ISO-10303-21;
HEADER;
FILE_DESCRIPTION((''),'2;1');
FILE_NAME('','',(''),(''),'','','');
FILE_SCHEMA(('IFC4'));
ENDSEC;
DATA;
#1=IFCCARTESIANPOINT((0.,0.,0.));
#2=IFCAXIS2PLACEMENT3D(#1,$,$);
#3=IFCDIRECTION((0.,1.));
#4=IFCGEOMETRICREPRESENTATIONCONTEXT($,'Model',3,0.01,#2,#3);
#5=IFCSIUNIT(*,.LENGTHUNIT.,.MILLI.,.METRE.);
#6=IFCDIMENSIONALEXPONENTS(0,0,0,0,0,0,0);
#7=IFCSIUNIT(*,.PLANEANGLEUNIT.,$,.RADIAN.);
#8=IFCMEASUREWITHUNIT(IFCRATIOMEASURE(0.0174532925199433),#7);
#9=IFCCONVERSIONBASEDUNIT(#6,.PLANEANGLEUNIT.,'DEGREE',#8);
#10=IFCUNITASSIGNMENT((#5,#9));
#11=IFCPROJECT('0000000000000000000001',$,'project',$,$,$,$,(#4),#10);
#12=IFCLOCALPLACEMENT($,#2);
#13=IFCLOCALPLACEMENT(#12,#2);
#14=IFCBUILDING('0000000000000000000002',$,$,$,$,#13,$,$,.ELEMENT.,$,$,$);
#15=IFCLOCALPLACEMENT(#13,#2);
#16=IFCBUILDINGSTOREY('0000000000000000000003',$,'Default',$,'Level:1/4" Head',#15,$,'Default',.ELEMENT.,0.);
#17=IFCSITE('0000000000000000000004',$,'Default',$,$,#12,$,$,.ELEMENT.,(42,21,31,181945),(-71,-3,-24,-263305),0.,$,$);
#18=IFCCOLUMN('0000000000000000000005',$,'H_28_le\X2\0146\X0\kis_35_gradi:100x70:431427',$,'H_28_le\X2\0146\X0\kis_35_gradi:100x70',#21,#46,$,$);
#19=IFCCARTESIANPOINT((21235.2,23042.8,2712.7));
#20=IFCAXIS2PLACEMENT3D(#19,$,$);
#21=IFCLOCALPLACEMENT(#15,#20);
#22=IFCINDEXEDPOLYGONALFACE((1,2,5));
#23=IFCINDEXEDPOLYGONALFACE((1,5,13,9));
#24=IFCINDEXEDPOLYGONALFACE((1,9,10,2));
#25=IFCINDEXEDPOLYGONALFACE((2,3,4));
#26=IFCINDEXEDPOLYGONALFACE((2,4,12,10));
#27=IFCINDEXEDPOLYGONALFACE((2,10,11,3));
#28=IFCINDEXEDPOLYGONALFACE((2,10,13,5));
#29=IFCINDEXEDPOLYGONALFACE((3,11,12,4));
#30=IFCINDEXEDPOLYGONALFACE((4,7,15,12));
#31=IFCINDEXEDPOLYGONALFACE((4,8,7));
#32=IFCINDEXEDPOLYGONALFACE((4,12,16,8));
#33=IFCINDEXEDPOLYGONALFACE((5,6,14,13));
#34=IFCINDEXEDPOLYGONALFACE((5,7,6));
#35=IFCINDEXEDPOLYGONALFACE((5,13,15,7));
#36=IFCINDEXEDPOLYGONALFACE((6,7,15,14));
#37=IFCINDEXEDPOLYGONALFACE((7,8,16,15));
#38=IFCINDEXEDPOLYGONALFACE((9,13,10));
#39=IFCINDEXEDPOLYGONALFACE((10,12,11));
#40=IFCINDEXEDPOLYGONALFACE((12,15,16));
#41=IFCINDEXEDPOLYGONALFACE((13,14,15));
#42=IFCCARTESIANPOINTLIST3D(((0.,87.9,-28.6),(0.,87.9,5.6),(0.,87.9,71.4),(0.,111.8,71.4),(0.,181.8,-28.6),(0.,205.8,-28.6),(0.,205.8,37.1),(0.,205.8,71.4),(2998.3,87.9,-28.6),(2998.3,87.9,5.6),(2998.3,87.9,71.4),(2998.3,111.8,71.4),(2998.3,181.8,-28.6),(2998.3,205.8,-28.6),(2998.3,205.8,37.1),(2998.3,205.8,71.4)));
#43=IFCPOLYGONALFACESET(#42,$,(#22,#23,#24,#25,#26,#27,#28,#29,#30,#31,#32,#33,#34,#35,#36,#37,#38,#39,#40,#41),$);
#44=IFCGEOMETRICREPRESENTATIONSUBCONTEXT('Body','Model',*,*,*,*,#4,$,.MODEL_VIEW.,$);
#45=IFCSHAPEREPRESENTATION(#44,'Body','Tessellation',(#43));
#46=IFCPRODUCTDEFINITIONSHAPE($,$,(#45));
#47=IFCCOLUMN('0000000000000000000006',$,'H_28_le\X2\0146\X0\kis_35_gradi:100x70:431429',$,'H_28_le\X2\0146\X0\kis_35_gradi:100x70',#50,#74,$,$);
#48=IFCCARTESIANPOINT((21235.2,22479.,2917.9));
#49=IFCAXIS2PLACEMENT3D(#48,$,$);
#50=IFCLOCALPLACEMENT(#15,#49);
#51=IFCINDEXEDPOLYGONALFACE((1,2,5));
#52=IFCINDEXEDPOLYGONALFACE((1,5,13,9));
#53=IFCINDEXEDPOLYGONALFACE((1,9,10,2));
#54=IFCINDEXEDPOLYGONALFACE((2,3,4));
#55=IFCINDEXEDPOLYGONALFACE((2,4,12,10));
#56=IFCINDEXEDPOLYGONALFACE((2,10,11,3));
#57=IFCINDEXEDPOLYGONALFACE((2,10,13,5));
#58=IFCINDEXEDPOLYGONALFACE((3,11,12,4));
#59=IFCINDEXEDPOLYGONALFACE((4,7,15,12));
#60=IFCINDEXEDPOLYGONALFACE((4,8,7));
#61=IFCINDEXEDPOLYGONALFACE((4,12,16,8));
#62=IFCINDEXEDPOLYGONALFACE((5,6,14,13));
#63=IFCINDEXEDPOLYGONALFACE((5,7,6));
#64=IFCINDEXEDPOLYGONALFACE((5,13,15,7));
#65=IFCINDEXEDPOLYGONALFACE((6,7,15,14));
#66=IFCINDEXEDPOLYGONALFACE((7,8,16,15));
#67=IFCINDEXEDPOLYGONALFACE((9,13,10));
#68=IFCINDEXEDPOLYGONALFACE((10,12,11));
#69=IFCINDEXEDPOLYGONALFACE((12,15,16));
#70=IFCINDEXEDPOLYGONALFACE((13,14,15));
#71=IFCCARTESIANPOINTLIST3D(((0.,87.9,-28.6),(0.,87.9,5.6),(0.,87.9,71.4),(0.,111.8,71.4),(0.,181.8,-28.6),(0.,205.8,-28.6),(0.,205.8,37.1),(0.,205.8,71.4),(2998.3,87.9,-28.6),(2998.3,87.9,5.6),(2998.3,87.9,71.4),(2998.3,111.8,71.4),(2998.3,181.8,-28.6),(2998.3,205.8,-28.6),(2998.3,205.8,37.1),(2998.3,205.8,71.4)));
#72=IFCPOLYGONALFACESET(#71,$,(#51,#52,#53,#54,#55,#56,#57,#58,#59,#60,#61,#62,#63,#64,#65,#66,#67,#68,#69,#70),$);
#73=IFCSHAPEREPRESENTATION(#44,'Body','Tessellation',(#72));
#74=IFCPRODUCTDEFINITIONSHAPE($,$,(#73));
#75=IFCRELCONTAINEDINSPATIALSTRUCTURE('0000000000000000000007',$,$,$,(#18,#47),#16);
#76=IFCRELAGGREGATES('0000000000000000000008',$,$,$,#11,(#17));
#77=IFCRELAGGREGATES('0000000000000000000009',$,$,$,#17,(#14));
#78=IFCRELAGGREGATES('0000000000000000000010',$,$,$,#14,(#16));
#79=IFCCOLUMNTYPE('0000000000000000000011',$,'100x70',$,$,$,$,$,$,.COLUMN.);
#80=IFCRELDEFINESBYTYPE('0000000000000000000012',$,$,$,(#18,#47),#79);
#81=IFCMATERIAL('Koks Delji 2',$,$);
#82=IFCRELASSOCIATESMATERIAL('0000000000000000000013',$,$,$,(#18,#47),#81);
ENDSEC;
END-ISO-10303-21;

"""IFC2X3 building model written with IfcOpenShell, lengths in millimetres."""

from ifc_helpers import new_model, entity, si_unit, converted_unit, direction, frame, frame_2d, origin, place, context, subcontext, project, spatial, rectangle, extrude, boolean, source, transform, mapped, material, type_object, type_shapes, element, save


model = new_model("IFC2X3")

# Units and contexts
model_context = context("Model", 3, precision=0.01, world=origin(), true_north=direction((0.0, 1.0)))
body_context = subcontext(model_context, "Body", "Model", "MODEL_VIEW")
ifc_project = project(units=[si_unit("LENGTHUNIT", "METRE", prefix="MILLI"), converted_unit("PLANEANGLEUNIT", "DEGREE", entity("IfcRatioMeasure", 0.0174532925199433), si_unit("PLANEANGLEUNIT", "RADIAN"), dimensions=[0, 0, 0, 0, 0, 0, 0])], contexts=[model_context])

# Site, building, storey
site_placement = place(None, origin())
site = spatial("IfcSite", under=ifc_project, at=site_placement, Name="Default", CompositionType="ELEMENT", RefLatitude=(42, 21, 31, 181945), RefLongitude=(-71, -3, -24, -263305), RefElevation=0.0)
building_placement = place(site_placement, origin())
building = spatial("IfcBuilding", under=site, at=building_placement, CompositionType="ELEMENT")
storey_placement = place(building_placement, origin())
storey = spatial("IfcBuildingStorey", under=building, at=storey_placement, Name="Default", ObjectType="Level:1/4\" Head", LongName="Default", CompositionType="ELEMENT", Elevation=0.0)

# Columns
ifc_material_1 = material(Name="Koks Delji 2")
column_type_1 = type_object("IfcColumnType", Name="100x70", PredefinedType="COLUMN")
shared_shape_1 = source(origin(), body_context, "Body", "CSG", [
    boolean("DIFFERENCE", extrude(rectangle(XDim=2998.3, YDim=117.9, at=frame_2d((0.0, 0.0), x_axis=(1.0, 0.0))), frame((1499.1, 146.8, -28.6)), (0.0, 0.0, 1.0), 100.0), extrude(rectangle(XDim=70.0, YDim=100.0, at=frame_2d((0.0, 0.0), x_axis=(0.0, 1.0))), frame((2998.3, 146.8, 21.4), z_axis=(1.0, 0.0, 0.0), x_axis=(0.0, 0.939693, -0.34202)), (0.0, 0.0, -1.0), 2998.3)),
])
type_shapes(column_type_1, [shared_shape_1])
for number, where, name in (
    (1, (21235.2, 23042.8, 2712.7), "H_28_leņkis_35_gradi:100x70:431427"),
    (2, (21235.2, 22479.0, 2917.9), "H_28_leņkis_35_gradi:100x70:431429"),
):
    element("IfcColumn", number, at=place(storey_placement, frame(where)), inside=storey, type_object=column_type_1, material=ifc_material_1, Name=name, ObjectType="H_28_leņkis_35_gradi:100x70", context=body_context, shape_type="MappedRepresentation", body=[
        mapped(shared_shape_1, transform((0.0, 0.0, 0.0), scale=1.0)),
    ])

save(model, "model.ifc")
